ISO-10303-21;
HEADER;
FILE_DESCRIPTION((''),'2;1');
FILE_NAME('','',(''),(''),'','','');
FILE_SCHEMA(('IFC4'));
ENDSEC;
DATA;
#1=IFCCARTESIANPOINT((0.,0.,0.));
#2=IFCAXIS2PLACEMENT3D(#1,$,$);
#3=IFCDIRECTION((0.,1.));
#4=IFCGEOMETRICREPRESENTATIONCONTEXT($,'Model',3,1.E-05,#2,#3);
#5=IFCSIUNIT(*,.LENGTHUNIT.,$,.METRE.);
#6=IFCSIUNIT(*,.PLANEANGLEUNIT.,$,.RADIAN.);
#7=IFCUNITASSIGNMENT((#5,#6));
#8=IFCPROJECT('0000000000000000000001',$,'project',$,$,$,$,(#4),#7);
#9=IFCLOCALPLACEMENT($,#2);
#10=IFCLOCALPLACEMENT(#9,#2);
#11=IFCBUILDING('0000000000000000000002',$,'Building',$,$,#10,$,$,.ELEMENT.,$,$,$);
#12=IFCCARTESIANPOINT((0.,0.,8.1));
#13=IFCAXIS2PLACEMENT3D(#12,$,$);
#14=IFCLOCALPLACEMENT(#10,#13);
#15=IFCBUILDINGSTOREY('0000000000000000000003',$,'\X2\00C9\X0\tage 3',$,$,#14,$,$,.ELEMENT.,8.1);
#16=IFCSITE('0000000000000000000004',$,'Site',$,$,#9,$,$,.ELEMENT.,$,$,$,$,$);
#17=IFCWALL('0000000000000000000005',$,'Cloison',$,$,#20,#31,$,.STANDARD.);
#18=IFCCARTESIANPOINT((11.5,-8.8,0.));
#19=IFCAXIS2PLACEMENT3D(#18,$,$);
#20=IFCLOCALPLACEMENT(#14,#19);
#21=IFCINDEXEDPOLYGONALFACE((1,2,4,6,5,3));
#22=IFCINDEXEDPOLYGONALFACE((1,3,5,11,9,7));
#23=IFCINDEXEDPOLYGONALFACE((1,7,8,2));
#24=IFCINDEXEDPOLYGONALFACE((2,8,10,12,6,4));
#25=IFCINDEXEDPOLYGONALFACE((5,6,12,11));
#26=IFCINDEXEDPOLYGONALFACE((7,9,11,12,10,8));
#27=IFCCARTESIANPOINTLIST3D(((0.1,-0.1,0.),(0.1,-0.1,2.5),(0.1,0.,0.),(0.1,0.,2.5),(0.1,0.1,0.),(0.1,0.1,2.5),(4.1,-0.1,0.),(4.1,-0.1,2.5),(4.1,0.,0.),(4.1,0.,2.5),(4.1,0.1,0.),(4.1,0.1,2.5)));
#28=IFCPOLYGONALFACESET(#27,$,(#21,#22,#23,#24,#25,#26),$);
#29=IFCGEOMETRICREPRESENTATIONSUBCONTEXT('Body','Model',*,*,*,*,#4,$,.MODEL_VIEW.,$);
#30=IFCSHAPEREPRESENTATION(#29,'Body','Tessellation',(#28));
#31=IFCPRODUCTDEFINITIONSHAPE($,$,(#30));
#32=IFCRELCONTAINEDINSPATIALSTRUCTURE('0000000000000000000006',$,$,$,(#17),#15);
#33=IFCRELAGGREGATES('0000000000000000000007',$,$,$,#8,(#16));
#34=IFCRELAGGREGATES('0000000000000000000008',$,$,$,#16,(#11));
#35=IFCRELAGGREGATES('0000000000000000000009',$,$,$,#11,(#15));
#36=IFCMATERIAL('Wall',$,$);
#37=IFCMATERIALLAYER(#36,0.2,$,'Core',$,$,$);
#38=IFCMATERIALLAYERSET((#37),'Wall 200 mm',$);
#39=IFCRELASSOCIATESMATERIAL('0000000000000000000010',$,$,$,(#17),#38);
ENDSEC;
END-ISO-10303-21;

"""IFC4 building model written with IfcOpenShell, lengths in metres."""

from ifc_helpers import new_model, si_unit, direction, frame, origin, place, context, subcontext, project, spatial, polyline, outline, extrude, material, layer, layer_set, layer_usage, element, save


model = new_model("IFC4")

# Units and contexts
model_context = context("Model", 3, precision=1e-05, world=origin(), true_north=direction((0.0, 1.0)))
body_context = subcontext(model_context, "Body", "Model", "MODEL_VIEW")
ifc_project = project(units=[si_unit("LENGTHUNIT", "METRE"), si_unit("PLANEANGLEUNIT", "RADIAN")], contexts=[model_context])

# Site, building, storey
site_placement = place(None, origin())
site = spatial("IfcSite", under=ifc_project, at=site_placement, Name="Site", CompositionType="ELEMENT")
building_placement = place(site_placement, origin())
building = spatial("IfcBuilding", under=site, at=building_placement, Name="Building", CompositionType="ELEMENT")
storey_placement = place(building_placement, frame((0.0, 0.0, 8.1)))
storey = spatial("IfcBuildingStorey", under=building, at=storey_placement, Name="Étage 3", CompositionType="ELEMENT", Elevation=8.1)

# Shared definitions
ifc_material = material(Name="Wall")
ifc_layer = layer(ifc_material, 0.2, Name="Core")
ifc_layer_set = layer_set([ifc_layer], Name="Wall 200 mm")
ifc_layer_usage = layer_usage(ifc_layer_set, "AXIS2", "POSITIVE", -0.1)

# Wall
wall_1_placement = place(storey_placement, frame((11.5, -8.8, 0.0)))
element("IfcWall", 1, at=wall_1_placement, inside=storey, material=ifc_layer_usage, Name="Cloison", PredefinedType="STANDARD", context=body_context, shape_type="SweptSolid", body=[
    extrude(outline(polyline([(0.1, 0.0), (0.1, -0.1), (4.1, -0.1), (4.1, 0.0), (4.1, 0.1), (0.1, 0.1), (0.1, 0.0)])), origin(), (0.0, 0.0, 1.0), 2.5),
])

save(model, "model.ifc")
